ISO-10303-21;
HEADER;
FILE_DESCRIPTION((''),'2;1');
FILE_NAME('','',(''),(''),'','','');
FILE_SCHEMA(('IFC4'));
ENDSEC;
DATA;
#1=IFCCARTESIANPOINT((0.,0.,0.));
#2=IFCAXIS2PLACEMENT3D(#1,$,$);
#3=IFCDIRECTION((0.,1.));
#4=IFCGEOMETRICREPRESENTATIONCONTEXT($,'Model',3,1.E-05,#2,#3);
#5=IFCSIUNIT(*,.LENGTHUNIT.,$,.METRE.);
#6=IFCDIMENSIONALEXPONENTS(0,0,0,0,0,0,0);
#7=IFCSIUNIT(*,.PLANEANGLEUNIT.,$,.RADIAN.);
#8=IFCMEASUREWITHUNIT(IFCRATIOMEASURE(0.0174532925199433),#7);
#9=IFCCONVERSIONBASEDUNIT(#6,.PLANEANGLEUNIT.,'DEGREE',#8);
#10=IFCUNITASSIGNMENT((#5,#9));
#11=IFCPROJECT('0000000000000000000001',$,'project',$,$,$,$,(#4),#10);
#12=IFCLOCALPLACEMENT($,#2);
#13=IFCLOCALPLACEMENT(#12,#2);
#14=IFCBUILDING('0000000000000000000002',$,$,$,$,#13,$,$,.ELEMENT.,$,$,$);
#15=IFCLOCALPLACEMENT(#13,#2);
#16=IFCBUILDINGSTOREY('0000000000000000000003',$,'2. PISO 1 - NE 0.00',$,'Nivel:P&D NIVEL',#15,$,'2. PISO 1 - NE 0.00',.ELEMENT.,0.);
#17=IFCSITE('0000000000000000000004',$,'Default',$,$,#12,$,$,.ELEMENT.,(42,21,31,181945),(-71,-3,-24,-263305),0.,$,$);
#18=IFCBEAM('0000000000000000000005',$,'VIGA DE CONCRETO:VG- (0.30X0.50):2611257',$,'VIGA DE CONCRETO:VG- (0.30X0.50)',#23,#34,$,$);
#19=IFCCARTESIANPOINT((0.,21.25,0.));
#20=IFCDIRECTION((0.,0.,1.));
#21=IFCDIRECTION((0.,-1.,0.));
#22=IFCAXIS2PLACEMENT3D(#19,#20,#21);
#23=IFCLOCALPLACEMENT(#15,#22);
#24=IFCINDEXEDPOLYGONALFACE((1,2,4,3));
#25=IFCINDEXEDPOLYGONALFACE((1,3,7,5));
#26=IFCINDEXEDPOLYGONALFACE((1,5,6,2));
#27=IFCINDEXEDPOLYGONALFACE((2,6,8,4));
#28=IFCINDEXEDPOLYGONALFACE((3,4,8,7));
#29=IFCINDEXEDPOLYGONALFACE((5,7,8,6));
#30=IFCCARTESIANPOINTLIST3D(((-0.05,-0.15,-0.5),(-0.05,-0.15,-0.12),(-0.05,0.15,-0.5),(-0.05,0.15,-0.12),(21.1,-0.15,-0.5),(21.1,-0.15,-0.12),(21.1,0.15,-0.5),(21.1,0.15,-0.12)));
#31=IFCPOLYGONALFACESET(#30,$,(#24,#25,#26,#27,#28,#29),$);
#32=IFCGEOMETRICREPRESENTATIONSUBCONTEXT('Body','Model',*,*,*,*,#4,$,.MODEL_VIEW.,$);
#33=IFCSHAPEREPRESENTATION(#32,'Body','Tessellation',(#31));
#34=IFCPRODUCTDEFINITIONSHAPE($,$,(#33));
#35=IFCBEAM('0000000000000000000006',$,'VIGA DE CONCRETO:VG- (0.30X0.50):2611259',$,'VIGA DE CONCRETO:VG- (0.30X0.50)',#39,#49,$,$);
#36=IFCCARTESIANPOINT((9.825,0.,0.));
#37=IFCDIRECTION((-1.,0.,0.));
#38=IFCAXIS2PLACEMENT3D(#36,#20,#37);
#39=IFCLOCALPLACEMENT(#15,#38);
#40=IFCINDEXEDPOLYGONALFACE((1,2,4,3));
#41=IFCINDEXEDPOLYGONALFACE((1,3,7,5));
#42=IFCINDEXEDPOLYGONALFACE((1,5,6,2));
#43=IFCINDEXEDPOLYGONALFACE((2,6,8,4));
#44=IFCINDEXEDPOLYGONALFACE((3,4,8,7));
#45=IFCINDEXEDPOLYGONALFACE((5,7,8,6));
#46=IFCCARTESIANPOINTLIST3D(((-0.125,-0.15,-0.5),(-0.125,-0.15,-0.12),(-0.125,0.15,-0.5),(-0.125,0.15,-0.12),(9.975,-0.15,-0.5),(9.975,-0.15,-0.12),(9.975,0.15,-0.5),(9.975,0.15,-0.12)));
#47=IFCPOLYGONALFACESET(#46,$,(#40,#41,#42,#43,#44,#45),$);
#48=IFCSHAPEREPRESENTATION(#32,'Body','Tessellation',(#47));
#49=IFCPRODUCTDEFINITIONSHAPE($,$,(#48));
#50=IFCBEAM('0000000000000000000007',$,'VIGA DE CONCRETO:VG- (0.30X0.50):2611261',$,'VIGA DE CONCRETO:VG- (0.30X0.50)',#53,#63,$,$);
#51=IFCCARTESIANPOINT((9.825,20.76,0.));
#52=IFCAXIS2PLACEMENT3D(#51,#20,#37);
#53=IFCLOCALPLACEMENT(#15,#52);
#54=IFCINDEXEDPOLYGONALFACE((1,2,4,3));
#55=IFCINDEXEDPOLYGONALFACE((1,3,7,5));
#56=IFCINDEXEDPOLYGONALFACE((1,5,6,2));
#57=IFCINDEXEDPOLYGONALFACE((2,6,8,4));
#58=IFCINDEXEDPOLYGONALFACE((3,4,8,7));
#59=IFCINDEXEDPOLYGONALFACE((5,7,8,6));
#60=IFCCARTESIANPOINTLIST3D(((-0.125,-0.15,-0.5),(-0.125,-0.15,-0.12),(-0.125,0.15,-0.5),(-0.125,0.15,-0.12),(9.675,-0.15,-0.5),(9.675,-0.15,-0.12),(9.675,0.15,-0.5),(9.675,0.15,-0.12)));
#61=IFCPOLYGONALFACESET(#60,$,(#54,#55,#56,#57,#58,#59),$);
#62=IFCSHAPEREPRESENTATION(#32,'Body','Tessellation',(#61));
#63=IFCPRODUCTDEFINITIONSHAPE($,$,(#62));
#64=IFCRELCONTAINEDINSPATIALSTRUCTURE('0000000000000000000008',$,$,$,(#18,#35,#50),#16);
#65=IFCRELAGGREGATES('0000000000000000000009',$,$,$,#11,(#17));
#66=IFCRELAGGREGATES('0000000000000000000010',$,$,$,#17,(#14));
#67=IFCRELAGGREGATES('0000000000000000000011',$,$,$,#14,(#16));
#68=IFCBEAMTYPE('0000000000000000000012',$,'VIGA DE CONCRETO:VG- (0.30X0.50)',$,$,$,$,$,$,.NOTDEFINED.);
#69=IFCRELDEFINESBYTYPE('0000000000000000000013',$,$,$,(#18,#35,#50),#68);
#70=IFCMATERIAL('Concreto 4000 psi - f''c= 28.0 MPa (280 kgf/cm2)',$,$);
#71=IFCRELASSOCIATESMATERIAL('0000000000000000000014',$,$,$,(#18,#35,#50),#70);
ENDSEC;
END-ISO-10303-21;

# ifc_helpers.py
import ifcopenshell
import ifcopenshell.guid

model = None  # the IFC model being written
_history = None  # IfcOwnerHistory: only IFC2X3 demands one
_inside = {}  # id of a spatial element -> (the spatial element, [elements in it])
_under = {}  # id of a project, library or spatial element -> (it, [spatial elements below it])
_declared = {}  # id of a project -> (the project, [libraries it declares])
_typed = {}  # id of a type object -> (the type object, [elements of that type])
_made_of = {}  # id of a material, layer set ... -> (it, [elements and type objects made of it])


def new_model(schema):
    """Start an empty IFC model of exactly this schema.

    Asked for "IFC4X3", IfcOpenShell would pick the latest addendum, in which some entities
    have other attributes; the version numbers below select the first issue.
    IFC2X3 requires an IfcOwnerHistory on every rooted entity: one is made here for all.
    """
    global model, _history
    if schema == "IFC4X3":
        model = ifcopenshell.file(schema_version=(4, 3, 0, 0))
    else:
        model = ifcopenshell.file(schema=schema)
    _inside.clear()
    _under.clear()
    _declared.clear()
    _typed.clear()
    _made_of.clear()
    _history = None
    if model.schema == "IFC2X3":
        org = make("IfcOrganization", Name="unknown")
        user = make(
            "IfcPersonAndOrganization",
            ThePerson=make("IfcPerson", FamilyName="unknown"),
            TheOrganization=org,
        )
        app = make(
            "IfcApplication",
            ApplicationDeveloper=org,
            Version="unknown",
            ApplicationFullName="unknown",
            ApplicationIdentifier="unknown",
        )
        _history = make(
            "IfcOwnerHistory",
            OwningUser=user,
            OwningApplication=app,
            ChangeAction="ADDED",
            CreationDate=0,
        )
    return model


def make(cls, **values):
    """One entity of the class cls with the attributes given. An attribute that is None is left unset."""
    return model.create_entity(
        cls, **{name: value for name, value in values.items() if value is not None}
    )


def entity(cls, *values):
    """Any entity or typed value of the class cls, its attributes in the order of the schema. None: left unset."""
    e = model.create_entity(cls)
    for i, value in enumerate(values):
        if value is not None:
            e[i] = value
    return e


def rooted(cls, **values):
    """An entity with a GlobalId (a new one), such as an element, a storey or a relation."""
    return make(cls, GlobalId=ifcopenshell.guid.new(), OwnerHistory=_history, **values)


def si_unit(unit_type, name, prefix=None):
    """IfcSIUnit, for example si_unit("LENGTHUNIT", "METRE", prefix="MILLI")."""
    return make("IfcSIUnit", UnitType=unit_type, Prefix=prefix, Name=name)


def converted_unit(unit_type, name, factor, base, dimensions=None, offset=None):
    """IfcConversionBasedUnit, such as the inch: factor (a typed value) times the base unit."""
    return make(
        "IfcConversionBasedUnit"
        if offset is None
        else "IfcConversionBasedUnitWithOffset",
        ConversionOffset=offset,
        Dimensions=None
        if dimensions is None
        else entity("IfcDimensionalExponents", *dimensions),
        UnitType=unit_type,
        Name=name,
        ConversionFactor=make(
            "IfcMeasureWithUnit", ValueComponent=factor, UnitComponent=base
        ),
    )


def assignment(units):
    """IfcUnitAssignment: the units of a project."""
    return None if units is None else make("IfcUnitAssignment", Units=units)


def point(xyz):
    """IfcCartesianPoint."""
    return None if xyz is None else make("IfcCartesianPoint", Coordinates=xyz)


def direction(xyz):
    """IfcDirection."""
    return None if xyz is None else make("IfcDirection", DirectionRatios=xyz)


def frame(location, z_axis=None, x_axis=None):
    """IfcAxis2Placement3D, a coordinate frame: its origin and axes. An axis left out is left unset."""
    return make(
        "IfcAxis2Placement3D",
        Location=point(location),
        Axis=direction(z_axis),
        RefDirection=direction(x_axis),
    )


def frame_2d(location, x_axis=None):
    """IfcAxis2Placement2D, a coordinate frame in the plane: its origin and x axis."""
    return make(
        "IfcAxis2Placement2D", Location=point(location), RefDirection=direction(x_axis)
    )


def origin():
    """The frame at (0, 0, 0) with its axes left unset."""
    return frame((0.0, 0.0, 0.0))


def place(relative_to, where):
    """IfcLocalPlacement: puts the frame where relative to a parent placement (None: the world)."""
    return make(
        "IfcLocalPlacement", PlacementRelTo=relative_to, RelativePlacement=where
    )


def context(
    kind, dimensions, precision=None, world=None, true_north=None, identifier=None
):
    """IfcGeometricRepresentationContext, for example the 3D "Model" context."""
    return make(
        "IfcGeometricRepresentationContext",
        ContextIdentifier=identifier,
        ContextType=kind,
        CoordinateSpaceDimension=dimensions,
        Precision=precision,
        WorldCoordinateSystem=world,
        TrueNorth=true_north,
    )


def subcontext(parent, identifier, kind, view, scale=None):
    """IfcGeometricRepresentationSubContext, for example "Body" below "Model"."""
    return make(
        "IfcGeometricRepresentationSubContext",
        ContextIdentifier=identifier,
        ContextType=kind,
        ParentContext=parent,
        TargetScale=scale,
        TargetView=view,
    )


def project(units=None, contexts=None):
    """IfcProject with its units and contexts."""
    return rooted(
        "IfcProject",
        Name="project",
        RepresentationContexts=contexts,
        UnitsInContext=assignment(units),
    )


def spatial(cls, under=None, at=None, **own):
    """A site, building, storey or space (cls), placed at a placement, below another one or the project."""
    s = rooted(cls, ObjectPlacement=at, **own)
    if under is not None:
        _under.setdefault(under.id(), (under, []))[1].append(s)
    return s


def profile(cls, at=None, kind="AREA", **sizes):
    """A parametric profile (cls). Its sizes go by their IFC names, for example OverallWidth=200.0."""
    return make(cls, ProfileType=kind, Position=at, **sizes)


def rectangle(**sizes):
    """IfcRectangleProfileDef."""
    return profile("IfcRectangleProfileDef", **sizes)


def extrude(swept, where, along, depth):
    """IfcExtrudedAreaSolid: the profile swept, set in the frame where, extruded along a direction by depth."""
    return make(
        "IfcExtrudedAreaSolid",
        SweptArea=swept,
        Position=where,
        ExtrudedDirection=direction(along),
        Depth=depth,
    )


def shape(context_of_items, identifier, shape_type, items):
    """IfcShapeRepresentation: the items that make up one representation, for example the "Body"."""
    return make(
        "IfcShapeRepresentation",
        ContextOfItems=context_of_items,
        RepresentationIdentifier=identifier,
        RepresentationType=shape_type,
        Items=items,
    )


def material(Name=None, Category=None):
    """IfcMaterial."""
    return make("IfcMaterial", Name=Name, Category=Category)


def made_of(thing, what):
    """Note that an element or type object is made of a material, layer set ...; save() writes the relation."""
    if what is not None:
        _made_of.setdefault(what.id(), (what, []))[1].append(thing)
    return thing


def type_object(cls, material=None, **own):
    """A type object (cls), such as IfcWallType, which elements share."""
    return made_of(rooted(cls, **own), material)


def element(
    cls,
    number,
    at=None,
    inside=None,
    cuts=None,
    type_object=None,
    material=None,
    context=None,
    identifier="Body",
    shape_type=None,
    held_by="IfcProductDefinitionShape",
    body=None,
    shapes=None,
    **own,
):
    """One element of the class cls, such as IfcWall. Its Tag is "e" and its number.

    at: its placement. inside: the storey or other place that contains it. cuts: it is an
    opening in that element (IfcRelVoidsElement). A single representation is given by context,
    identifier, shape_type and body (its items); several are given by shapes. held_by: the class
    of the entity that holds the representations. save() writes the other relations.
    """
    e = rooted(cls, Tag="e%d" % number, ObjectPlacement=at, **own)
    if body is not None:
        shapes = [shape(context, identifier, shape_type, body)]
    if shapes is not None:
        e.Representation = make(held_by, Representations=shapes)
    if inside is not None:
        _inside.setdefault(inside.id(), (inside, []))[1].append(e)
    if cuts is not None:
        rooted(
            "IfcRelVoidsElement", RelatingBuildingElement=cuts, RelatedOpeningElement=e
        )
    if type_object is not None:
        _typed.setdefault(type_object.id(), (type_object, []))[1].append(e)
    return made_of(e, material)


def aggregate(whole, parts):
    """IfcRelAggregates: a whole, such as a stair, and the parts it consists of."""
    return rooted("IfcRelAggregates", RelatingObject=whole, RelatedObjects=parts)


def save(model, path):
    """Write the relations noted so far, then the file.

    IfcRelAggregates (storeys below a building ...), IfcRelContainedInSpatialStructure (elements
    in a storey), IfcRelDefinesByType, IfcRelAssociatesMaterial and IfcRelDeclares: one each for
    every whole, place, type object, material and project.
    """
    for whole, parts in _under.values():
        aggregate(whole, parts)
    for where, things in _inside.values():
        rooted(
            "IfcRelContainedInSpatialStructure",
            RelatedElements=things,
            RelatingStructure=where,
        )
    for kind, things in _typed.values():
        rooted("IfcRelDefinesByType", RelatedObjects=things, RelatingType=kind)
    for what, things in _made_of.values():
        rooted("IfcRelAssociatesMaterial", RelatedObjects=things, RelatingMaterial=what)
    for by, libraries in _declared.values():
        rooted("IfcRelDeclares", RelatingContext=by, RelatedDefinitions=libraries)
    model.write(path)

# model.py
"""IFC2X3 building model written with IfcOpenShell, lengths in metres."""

from ifc_helpers import new_model, entity, si_unit, converted_unit, direction, frame, frame_2d, origin, place, context, subcontext, project, spatial, rectangle, extrude, material, type_object, element, save


model = new_model("IFC2X3")

# Units and contexts
model_context = context("Model", 3, precision=1e-05, world=origin(), true_north=direction((0.0, 1.0)))
body_context = subcontext(model_context, "Body", "Model", "MODEL_VIEW")
ifc_project = project(units=[si_unit("LENGTHUNIT", "METRE"), converted_unit("PLANEANGLEUNIT", "DEGREE", entity("IfcRatioMeasure", 0.0174532925199433), si_unit("PLANEANGLEUNIT", "RADIAN"), dimensions=[0, 0, 0, 0, 0, 0, 0])], contexts=[model_context])

# Site, building, storey
site_placement = place(None, origin())
site = spatial("IfcSite", under=ifc_project, at=site_placement, Name="Default", CompositionType="ELEMENT", RefLatitude=(42, 21, 31, 181945), RefLongitude=(-71, -3, -24, -263305), RefElevation=0.0)
building_placement = place(site_placement, origin())
building = spatial("IfcBuilding", under=site, at=building_placement, CompositionType="ELEMENT")
storey_placement = place(building_placement, origin())
storey = spatial("IfcBuildingStorey", under=building, at=storey_placement, Name="2. PISO 1 - NE 0.00", ObjectType="Nivel:P&D NIVEL", LongName="2. PISO 1 - NE 0.00", CompositionType="ELEMENT", Elevation=0.0)

# Shared definitions
ifc_material = material(Name="Concreto 4000 psi - f'c= 28.0 MPa (280 kgf/cm2)")

# Beams
beam_type_1 = type_object("IfcBeamType", Name="VIGA DE CONCRETO:VG- (0.30X0.50)", PredefinedType="NOTDEFINED")
beam_1_placement = place(storey_placement, frame((0.0, 21.25, 0.0), z_axis=(0.0, 0.0, 1.0), x_axis=(0.0, -1.0, 0.0)))
element("IfcBeam", 1, at=beam_1_placement, inside=storey, type_object=beam_type_1, material=ifc_material, Name="VIGA DE CONCRETO:VG- (0.30X0.50):2611257", ObjectType="VIGA DE CONCRETO:VG- (0.30X0.50)", context=body_context, shape_type="SweptSolid", body=[
    extrude(rectangle(XDim=0.38, YDim=0.3, at=frame_2d((0.0, 0.0), x_axis=(1.0, 0.0))), frame((-0.05, 0.0, -0.31), z_axis=(1.0, 0.0, 0.0), x_axis=(0.0, 0.0, -1.0)), (0.0, 0.0, 1.0), 21.15),
])
beam_2_placement = place(storey_placement, frame((9.825, 0.0, 0.0), z_axis=(0.0, 0.0, 1.0), x_axis=(-1.0, 0.0, 0.0)))
element("IfcBeam", 2, at=beam_2_placement, inside=storey, type_object=beam_type_1, material=ifc_material, Name="VIGA DE CONCRETO:VG- (0.30X0.50):2611259", ObjectType="VIGA DE CONCRETO:VG- (0.30X0.50)", context=body_context, shape_type="SweptSolid", body=[
    extrude(rectangle(XDim=0.38, YDim=0.3, at=frame_2d((0.0, 0.0), x_axis=(1.0, 0.0))), frame((-0.125, 0.0, -0.31), z_axis=(1.0, 0.0, 0.0), x_axis=(0.0, 0.0, -1.0)), (0.0, 0.0, 1.0), 10.1),
])
beam_3_placement = place(storey_placement, frame((9.825, 20.76, 0.0), z_axis=(0.0, 0.0, 1.0), x_axis=(-1.0, 0.0, 0.0)))
element("IfcBeam", 3, at=beam_3_placement, inside=storey, type_object=beam_type_1, material=ifc_material, Name="VIGA DE CONCRETO:VG- (0.30X0.50):2611261", ObjectType="VIGA DE CONCRETO:VG- (0.30X0.50)", context=body_context, shape_type="SweptSolid", body=[
    extrude(rectangle(XDim=0.38, YDim=0.3, at=frame_2d((0.0, 0.0), x_axis=(1.0, 0.0))), frame((-0.125, 0.0, -0.31), z_axis=(1.0, 0.0, 0.0), x_axis=(0.0, 0.0, -1.0)), (0.0, 0.0, 1.0), 9.8),
])

save(model, "model.ifc")
